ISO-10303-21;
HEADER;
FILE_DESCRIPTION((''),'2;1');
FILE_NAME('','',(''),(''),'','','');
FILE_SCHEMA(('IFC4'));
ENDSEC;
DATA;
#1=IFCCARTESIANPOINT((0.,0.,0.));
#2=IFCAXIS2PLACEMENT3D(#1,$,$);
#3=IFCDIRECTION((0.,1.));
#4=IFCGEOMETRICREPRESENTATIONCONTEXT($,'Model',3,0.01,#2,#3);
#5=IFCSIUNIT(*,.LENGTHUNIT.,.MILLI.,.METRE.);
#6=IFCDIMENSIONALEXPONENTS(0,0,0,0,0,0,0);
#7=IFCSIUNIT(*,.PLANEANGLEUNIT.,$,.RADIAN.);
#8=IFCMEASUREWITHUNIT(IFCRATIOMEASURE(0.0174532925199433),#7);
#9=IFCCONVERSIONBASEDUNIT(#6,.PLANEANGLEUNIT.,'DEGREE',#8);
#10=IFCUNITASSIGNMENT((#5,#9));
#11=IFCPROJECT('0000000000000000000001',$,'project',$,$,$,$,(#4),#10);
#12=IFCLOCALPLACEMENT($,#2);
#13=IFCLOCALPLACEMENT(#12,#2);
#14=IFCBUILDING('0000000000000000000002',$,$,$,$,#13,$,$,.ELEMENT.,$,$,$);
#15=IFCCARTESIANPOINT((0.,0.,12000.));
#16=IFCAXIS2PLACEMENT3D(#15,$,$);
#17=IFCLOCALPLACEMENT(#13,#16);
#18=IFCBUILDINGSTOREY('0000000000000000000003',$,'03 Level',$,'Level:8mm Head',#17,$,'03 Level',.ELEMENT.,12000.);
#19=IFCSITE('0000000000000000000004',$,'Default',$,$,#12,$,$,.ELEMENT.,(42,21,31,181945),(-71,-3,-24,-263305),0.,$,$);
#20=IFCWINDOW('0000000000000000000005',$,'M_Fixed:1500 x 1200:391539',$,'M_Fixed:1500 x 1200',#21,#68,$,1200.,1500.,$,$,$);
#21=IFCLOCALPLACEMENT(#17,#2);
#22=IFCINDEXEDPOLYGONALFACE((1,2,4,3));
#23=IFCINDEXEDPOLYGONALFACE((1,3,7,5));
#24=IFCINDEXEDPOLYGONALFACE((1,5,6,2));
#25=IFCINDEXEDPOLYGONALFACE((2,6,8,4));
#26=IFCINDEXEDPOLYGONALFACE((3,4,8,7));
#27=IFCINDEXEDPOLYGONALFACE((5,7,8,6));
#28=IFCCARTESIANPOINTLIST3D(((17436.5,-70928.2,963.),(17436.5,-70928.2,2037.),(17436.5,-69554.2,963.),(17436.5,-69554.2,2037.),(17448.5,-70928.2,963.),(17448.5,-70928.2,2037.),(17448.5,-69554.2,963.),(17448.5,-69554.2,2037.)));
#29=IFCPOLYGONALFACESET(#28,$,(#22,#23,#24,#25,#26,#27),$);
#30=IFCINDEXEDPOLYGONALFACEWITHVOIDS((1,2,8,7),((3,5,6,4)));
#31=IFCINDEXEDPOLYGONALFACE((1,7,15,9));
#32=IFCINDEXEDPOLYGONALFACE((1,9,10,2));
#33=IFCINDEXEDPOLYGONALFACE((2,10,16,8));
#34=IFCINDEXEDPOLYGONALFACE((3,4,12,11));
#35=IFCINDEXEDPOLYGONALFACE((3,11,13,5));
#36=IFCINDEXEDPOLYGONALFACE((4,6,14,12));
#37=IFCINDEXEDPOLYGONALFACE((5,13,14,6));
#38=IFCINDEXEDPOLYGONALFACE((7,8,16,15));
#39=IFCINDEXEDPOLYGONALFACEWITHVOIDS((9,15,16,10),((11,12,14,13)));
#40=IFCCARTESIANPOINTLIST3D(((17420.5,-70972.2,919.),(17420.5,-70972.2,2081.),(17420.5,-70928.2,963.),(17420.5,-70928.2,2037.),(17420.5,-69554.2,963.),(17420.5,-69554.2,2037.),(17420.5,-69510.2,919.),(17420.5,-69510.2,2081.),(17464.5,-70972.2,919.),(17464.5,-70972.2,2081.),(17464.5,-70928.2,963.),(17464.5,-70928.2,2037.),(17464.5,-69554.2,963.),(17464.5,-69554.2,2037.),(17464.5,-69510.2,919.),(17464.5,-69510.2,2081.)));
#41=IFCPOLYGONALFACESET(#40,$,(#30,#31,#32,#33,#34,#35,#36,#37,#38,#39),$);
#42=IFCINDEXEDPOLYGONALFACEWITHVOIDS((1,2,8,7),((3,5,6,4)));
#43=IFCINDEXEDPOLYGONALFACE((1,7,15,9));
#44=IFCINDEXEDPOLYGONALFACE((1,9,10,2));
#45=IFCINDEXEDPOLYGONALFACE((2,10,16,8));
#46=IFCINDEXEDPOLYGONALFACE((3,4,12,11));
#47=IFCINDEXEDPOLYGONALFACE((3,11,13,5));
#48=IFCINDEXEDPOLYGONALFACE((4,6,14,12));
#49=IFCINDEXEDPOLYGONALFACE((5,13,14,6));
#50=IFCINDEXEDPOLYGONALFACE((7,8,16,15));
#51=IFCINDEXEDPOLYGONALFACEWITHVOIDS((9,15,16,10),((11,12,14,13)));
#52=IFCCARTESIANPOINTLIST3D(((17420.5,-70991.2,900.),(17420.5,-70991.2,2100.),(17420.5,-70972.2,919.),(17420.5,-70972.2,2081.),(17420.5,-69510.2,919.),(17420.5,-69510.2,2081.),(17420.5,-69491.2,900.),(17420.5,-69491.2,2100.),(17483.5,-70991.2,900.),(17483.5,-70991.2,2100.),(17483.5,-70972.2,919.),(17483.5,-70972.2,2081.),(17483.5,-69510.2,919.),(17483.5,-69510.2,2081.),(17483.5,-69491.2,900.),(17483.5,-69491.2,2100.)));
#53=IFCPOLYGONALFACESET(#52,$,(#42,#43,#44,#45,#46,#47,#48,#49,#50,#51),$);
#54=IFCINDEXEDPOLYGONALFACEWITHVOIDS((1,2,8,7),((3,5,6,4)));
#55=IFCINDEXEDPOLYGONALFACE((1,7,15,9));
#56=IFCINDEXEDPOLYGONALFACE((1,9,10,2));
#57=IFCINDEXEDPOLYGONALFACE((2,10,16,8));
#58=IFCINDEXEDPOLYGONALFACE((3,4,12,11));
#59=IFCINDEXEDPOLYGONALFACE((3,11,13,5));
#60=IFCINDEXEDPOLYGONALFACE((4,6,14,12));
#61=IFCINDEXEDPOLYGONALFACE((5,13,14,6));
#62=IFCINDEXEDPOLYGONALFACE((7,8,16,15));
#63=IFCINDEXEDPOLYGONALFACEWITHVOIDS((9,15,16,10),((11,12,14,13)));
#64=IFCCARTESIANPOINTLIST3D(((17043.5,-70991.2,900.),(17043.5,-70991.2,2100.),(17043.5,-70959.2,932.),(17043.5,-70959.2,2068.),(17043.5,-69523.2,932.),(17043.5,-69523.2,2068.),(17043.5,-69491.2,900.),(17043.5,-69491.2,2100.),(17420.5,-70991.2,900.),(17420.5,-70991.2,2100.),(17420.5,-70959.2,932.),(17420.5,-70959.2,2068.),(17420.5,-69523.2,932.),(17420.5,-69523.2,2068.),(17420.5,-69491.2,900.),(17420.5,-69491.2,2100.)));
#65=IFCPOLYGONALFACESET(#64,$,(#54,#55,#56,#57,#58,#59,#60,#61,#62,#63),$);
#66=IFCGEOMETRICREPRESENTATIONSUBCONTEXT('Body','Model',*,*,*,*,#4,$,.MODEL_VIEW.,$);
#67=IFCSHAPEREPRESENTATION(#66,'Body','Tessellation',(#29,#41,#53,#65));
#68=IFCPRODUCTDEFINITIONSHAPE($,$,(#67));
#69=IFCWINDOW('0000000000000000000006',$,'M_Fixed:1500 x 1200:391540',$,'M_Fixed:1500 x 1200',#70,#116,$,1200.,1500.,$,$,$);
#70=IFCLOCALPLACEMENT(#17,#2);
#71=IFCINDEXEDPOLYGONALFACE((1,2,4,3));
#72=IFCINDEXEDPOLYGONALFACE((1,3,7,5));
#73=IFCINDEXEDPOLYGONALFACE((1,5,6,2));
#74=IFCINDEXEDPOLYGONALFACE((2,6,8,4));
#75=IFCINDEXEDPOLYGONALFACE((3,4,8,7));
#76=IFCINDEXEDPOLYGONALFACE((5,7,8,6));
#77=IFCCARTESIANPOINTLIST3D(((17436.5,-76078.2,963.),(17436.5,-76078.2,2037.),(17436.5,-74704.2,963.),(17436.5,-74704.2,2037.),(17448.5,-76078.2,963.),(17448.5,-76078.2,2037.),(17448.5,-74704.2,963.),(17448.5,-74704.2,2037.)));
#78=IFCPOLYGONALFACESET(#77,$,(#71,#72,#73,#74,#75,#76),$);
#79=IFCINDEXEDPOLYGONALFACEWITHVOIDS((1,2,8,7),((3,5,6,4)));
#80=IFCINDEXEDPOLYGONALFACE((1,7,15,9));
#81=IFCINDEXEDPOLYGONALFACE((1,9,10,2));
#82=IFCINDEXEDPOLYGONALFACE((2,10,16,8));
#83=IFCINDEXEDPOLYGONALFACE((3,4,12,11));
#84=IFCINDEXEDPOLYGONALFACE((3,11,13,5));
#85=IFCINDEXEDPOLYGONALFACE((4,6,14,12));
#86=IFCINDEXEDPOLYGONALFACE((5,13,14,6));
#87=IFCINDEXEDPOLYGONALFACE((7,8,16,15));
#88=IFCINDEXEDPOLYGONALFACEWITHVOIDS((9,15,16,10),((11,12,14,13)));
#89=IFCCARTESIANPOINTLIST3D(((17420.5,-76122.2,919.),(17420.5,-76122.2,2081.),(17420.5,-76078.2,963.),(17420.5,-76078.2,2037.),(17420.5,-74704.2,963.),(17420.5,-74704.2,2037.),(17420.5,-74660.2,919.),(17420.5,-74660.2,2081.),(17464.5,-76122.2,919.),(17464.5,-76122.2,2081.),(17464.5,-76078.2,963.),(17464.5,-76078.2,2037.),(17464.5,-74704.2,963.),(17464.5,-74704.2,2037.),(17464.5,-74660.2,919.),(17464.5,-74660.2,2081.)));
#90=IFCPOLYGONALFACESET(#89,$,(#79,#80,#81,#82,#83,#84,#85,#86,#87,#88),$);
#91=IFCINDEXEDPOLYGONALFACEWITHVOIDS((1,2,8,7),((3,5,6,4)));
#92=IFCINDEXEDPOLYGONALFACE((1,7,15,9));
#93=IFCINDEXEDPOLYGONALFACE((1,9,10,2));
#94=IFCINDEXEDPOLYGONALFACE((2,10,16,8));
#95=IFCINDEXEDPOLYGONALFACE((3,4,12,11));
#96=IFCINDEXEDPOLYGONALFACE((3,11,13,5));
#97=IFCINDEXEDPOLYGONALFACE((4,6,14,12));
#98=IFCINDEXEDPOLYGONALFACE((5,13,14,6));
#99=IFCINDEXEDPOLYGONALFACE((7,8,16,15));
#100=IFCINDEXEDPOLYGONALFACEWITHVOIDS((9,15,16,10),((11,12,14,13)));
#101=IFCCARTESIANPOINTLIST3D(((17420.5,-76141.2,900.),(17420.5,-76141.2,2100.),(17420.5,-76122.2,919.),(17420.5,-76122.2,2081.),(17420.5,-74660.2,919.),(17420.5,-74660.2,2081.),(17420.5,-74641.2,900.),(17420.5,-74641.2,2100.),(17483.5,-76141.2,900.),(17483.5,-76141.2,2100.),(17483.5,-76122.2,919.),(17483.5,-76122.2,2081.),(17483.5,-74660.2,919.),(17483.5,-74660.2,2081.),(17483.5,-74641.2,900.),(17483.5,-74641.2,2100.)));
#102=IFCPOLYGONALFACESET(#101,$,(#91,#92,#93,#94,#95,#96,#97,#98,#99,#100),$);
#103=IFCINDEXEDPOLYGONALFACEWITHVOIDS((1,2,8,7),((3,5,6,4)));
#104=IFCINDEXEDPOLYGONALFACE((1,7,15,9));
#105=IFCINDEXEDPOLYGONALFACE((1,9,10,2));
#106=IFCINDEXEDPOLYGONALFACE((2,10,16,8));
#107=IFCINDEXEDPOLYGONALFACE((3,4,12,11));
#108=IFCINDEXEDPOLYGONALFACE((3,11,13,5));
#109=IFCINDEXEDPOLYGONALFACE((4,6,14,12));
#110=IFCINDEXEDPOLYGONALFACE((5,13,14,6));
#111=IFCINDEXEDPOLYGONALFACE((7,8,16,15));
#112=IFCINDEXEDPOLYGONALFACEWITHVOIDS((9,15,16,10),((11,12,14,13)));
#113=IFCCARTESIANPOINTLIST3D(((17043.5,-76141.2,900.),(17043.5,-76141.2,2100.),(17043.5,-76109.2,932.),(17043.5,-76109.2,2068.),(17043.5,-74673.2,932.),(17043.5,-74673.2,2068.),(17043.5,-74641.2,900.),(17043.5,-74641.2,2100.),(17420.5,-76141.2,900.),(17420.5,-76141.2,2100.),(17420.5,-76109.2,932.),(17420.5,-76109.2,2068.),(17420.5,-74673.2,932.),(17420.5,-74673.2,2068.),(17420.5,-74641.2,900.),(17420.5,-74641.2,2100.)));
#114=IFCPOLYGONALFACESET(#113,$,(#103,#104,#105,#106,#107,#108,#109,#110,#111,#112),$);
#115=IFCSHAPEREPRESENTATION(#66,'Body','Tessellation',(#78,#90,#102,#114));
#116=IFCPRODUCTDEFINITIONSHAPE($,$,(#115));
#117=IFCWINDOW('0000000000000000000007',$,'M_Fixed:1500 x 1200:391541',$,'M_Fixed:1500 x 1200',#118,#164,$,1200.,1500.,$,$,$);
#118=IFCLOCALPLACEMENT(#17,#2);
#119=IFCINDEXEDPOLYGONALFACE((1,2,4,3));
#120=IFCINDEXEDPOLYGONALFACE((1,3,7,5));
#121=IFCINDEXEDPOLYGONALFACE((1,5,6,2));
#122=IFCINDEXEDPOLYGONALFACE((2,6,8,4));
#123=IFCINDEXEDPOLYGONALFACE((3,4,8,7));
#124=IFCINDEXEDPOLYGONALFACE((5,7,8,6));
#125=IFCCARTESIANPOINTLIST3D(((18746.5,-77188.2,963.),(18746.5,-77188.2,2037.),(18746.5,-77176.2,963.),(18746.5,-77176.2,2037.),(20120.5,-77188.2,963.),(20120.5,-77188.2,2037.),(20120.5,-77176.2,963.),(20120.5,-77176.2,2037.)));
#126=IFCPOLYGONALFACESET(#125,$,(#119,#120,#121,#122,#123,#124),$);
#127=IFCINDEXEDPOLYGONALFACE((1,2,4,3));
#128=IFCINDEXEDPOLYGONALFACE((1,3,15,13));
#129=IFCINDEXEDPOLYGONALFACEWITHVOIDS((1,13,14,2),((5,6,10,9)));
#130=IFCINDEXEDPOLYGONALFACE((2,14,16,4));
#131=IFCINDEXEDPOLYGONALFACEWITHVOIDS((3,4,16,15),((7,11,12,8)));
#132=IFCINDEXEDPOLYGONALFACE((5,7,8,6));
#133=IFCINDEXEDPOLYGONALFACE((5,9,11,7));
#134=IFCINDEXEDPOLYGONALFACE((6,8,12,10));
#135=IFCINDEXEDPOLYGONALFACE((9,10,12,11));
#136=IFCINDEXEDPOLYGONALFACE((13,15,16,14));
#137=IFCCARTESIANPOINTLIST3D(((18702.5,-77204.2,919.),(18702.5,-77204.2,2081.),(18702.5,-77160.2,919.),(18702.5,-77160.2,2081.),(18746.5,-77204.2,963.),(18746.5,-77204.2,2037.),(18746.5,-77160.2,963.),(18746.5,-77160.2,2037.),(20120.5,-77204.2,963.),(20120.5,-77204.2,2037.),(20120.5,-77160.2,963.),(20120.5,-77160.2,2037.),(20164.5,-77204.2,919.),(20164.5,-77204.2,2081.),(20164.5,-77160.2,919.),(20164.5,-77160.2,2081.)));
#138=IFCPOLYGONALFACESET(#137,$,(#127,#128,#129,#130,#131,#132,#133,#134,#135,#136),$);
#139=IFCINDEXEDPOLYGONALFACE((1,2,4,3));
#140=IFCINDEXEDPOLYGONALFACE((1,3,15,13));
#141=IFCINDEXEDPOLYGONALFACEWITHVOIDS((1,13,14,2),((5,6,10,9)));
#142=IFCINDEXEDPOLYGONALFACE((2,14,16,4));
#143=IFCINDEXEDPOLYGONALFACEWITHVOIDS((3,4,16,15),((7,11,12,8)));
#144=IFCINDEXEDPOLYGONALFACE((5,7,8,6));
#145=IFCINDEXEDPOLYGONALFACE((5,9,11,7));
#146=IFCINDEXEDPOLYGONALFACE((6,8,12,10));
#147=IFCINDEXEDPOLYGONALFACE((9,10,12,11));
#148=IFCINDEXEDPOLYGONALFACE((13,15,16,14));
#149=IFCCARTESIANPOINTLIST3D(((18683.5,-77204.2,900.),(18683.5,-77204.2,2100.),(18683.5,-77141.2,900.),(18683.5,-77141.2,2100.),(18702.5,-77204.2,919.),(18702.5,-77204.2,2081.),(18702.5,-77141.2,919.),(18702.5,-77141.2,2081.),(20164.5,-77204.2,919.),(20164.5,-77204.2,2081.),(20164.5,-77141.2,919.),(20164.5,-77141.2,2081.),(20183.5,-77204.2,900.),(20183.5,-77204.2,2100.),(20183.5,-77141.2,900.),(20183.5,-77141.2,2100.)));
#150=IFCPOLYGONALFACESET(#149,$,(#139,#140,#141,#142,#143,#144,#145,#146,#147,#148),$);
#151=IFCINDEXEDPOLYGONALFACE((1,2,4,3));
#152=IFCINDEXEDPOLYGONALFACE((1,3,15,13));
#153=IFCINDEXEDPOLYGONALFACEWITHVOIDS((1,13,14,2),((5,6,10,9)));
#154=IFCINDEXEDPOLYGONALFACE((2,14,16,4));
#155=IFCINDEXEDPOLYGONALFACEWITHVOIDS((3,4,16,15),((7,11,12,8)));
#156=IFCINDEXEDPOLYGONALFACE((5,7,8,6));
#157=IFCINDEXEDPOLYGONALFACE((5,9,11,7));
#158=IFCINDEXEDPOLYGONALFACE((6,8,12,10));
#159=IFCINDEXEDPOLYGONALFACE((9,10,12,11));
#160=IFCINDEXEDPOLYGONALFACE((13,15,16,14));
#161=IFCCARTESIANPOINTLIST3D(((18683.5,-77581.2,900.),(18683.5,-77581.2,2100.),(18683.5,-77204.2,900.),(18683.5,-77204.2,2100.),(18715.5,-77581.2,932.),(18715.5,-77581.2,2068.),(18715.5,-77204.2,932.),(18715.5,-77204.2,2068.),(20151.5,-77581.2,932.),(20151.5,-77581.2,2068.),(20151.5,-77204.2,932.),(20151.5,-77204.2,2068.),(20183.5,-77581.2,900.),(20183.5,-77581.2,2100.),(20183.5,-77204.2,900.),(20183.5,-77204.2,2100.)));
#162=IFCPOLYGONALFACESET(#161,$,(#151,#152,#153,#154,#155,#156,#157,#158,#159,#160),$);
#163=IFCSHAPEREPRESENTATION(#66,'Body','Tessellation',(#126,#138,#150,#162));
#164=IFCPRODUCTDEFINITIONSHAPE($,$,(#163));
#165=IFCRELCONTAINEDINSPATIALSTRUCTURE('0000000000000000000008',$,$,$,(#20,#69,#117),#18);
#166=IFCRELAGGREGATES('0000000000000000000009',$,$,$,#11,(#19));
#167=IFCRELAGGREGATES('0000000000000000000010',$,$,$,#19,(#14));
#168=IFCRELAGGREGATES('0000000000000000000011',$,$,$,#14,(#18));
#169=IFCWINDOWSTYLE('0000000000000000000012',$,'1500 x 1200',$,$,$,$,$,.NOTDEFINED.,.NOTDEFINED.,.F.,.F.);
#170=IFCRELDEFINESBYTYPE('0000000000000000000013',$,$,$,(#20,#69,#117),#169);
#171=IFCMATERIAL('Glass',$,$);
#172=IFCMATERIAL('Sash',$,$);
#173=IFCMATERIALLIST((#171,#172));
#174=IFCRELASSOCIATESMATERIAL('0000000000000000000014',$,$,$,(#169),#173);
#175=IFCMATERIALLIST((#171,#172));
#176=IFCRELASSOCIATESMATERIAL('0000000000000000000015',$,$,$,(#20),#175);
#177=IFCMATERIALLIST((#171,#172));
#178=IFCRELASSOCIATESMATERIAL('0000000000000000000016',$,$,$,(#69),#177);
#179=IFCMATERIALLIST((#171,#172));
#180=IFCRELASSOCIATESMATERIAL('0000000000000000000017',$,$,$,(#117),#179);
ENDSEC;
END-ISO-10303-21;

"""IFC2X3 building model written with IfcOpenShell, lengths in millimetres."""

from ifc_helpers import new_model, entity, si_unit, converted_unit, direction, frame, origin, origin_2d_with_axis, place, context, subcontext, project, spatial, polyline, rectangle, outline, extrude, source, transform, mapped, material, material_list, type_object, type_shapes, element, save


model = new_model("IFC2X3")

# Units and contexts
model_context = context("Model", 3, precision=0.01, world=origin(), true_north=direction((0.0, 1.0)))
body_context = subcontext(model_context, "Body", "Model", "MODEL_VIEW")
ifc_project = project(units=[si_unit("LENGTHUNIT", "METRE", prefix="MILLI"), converted_unit("PLANEANGLEUNIT", "DEGREE", entity("IfcRatioMeasure", 0.0174532925199433), si_unit("PLANEANGLEUNIT", "RADIAN"), dimensions=[0, 0, 0, 0, 0, 0, 0])], contexts=[model_context])

# Site, building, storey
site_placement = place(None, origin())
site = spatial("IfcSite", under=ifc_project, at=site_placement, Name="Default", CompositionType="ELEMENT", RefLatitude=(42, 21, 31, 181945), RefLongitude=(-71, -3, -24, -263305), RefElevation=0.0)
building_placement = place(site_placement, origin())
building = spatial("IfcBuilding", under=site, at=building_placement, CompositionType="ELEMENT")
storey_placement = place(building_placement, frame((0.0, 0.0, 12000.0)))
storey = spatial("IfcBuildingStorey", under=building, at=storey_placement, Name="03 Level", ObjectType="Level:8mm Head", LongName="03 Level", CompositionType="ELEMENT", Elevation=12000.0)

# Windows
ifc_material_1 = material(Name="Glass")
ifc_material_2 = material(Name="Sash")
ifc_material_list_1 = material_list([ifc_material_1, ifc_material_2])
ifc_material_list_2 = material_list([ifc_material_1, ifc_material_2])
window_style_1 = type_object("IfcWindowStyle", Name="1500 x 1200", ConstructionType="NOTDEFINED", OperationType="NOTDEFINED", ParameterTakesPrecedence=False, Sizeable=False, material=ifc_material_list_2)
shared_shape_1 = source(origin(), body_context, "Body", "SweptSolid", [
    extrude(rectangle(XDim=12.0, YDim=1374.0, at=origin_2d_with_axis()), frame((750.0, 399.0, 63.0), z_axis=(0.0, 0.0, 1.0), x_axis=(0.0, -1.0, 0.0)), (0.0, 0.0, 1.0), 1074.0),
    extrude(outline(polyline([(-731.0, -581.0), (731.0, -581.0), (731.0, 581.0), (-731.0, 581.0), (-731.0, -581.0)]), holes=[polyline([(-687.0, -537.0), (-687.0, 537.0), (687.0, 537.0), (687.0, -537.0), (-687.0, -537.0)])]), frame((750.0, 377.0, 600.0), z_axis=(0.0, 1.0, 0.0), x_axis=(1.0, 0.0, 0.0)), (0.0, 0.0, 1.0), 44.0),
    extrude(outline(polyline([(-750.0, -600.0), (750.0, -600.0), (750.0, 600.0), (-750.0, 600.0), (-750.0, -600.0)]), holes=[polyline([(-731.0, -581.0), (-731.0, 581.0), (731.0, 581.0), (731.0, -581.0), (-731.0, -581.0)])]), frame((750.0, 377.0, 600.0), z_axis=(0.0, 1.0, 0.0), x_axis=(1.0, 0.0, 0.0)), (0.0, 0.0, 1.0), 63.0),
    extrude(outline(polyline([(-750.0, -600.0), (750.0, -600.0), (750.0, 600.0), (-750.0, 600.0), (-750.0, -600.0)]), holes=[polyline([(-718.0, -568.0), (-718.0, 568.0), (718.0, 568.0), (718.0, -568.0), (-718.0, -568.0)])]), frame((750.0, 0.0, 600.0), z_axis=(0.0, 1.0, 0.0), x_axis=(1.0, 0.0, 0.0)), (0.0, 0.0, 1.0), 377.0),
])
type_shapes(window_style_1, [shared_shape_1])
window_1_placement = place(storey_placement, frame((17043.5, -69491.2, 900.0), z_axis=(0.0, 0.0, 1.0), x_axis=(0.0, -1.0, 0.0)))
element("IfcWindow", 1, at=window_1_placement, inside=storey, type_object=window_style_1, material=ifc_material_list_1, Name="M_Fixed:1500 x 1200:391539", ObjectType="M_Fixed:1500 x 1200", OverallHeight=1200.0, OverallWidth=1500.0, context=body_context, shape_type="MappedRepresentation", body=[
    mapped(shared_shape_1, transform((0.0, 0.0, 0.0), scale=1.0)),
])
ifc_material_list_3 = material_list([ifc_material_1, ifc_material_2])
window_2_placement = place(storey_placement, frame((17043.5, -74641.2, 900.0), z_axis=(0.0, 0.0, 1.0), x_axis=(0.0, -1.0, 0.0)))
element("IfcWindow", 2, at=window_2_placement, inside=storey, type_object=window_style_1, material=ifc_material_list_3, Name="M_Fixed:1500 x 1200:391540", ObjectType="M_Fixed:1500 x 1200", OverallHeight=1200.0, OverallWidth=1500.0, context=body_context, shape_type="MappedRepresentation", body=[
    mapped(shared_shape_1, transform((0.0, 0.0, 0.0), scale=1.0)),
])
ifc_material_list_4 = material_list([ifc_material_1, ifc_material_2])
window_3_placement = place(storey_placement, frame((18683.5, -77581.2, 900.0)))
element("IfcWindow", 3, at=window_3_placement, inside=storey, type_object=window_style_1, material=ifc_material_list_4, Name="M_Fixed:1500 x 1200:391541", ObjectType="M_Fixed:1500 x 1200", OverallHeight=1200.0, OverallWidth=1500.0, context=body_context, shape_type="MappedRepresentation", body=[
    mapped(shared_shape_1, transform((0.0, 0.0, 0.0), scale=1.0)),
])

save(model, "model.ifc")
